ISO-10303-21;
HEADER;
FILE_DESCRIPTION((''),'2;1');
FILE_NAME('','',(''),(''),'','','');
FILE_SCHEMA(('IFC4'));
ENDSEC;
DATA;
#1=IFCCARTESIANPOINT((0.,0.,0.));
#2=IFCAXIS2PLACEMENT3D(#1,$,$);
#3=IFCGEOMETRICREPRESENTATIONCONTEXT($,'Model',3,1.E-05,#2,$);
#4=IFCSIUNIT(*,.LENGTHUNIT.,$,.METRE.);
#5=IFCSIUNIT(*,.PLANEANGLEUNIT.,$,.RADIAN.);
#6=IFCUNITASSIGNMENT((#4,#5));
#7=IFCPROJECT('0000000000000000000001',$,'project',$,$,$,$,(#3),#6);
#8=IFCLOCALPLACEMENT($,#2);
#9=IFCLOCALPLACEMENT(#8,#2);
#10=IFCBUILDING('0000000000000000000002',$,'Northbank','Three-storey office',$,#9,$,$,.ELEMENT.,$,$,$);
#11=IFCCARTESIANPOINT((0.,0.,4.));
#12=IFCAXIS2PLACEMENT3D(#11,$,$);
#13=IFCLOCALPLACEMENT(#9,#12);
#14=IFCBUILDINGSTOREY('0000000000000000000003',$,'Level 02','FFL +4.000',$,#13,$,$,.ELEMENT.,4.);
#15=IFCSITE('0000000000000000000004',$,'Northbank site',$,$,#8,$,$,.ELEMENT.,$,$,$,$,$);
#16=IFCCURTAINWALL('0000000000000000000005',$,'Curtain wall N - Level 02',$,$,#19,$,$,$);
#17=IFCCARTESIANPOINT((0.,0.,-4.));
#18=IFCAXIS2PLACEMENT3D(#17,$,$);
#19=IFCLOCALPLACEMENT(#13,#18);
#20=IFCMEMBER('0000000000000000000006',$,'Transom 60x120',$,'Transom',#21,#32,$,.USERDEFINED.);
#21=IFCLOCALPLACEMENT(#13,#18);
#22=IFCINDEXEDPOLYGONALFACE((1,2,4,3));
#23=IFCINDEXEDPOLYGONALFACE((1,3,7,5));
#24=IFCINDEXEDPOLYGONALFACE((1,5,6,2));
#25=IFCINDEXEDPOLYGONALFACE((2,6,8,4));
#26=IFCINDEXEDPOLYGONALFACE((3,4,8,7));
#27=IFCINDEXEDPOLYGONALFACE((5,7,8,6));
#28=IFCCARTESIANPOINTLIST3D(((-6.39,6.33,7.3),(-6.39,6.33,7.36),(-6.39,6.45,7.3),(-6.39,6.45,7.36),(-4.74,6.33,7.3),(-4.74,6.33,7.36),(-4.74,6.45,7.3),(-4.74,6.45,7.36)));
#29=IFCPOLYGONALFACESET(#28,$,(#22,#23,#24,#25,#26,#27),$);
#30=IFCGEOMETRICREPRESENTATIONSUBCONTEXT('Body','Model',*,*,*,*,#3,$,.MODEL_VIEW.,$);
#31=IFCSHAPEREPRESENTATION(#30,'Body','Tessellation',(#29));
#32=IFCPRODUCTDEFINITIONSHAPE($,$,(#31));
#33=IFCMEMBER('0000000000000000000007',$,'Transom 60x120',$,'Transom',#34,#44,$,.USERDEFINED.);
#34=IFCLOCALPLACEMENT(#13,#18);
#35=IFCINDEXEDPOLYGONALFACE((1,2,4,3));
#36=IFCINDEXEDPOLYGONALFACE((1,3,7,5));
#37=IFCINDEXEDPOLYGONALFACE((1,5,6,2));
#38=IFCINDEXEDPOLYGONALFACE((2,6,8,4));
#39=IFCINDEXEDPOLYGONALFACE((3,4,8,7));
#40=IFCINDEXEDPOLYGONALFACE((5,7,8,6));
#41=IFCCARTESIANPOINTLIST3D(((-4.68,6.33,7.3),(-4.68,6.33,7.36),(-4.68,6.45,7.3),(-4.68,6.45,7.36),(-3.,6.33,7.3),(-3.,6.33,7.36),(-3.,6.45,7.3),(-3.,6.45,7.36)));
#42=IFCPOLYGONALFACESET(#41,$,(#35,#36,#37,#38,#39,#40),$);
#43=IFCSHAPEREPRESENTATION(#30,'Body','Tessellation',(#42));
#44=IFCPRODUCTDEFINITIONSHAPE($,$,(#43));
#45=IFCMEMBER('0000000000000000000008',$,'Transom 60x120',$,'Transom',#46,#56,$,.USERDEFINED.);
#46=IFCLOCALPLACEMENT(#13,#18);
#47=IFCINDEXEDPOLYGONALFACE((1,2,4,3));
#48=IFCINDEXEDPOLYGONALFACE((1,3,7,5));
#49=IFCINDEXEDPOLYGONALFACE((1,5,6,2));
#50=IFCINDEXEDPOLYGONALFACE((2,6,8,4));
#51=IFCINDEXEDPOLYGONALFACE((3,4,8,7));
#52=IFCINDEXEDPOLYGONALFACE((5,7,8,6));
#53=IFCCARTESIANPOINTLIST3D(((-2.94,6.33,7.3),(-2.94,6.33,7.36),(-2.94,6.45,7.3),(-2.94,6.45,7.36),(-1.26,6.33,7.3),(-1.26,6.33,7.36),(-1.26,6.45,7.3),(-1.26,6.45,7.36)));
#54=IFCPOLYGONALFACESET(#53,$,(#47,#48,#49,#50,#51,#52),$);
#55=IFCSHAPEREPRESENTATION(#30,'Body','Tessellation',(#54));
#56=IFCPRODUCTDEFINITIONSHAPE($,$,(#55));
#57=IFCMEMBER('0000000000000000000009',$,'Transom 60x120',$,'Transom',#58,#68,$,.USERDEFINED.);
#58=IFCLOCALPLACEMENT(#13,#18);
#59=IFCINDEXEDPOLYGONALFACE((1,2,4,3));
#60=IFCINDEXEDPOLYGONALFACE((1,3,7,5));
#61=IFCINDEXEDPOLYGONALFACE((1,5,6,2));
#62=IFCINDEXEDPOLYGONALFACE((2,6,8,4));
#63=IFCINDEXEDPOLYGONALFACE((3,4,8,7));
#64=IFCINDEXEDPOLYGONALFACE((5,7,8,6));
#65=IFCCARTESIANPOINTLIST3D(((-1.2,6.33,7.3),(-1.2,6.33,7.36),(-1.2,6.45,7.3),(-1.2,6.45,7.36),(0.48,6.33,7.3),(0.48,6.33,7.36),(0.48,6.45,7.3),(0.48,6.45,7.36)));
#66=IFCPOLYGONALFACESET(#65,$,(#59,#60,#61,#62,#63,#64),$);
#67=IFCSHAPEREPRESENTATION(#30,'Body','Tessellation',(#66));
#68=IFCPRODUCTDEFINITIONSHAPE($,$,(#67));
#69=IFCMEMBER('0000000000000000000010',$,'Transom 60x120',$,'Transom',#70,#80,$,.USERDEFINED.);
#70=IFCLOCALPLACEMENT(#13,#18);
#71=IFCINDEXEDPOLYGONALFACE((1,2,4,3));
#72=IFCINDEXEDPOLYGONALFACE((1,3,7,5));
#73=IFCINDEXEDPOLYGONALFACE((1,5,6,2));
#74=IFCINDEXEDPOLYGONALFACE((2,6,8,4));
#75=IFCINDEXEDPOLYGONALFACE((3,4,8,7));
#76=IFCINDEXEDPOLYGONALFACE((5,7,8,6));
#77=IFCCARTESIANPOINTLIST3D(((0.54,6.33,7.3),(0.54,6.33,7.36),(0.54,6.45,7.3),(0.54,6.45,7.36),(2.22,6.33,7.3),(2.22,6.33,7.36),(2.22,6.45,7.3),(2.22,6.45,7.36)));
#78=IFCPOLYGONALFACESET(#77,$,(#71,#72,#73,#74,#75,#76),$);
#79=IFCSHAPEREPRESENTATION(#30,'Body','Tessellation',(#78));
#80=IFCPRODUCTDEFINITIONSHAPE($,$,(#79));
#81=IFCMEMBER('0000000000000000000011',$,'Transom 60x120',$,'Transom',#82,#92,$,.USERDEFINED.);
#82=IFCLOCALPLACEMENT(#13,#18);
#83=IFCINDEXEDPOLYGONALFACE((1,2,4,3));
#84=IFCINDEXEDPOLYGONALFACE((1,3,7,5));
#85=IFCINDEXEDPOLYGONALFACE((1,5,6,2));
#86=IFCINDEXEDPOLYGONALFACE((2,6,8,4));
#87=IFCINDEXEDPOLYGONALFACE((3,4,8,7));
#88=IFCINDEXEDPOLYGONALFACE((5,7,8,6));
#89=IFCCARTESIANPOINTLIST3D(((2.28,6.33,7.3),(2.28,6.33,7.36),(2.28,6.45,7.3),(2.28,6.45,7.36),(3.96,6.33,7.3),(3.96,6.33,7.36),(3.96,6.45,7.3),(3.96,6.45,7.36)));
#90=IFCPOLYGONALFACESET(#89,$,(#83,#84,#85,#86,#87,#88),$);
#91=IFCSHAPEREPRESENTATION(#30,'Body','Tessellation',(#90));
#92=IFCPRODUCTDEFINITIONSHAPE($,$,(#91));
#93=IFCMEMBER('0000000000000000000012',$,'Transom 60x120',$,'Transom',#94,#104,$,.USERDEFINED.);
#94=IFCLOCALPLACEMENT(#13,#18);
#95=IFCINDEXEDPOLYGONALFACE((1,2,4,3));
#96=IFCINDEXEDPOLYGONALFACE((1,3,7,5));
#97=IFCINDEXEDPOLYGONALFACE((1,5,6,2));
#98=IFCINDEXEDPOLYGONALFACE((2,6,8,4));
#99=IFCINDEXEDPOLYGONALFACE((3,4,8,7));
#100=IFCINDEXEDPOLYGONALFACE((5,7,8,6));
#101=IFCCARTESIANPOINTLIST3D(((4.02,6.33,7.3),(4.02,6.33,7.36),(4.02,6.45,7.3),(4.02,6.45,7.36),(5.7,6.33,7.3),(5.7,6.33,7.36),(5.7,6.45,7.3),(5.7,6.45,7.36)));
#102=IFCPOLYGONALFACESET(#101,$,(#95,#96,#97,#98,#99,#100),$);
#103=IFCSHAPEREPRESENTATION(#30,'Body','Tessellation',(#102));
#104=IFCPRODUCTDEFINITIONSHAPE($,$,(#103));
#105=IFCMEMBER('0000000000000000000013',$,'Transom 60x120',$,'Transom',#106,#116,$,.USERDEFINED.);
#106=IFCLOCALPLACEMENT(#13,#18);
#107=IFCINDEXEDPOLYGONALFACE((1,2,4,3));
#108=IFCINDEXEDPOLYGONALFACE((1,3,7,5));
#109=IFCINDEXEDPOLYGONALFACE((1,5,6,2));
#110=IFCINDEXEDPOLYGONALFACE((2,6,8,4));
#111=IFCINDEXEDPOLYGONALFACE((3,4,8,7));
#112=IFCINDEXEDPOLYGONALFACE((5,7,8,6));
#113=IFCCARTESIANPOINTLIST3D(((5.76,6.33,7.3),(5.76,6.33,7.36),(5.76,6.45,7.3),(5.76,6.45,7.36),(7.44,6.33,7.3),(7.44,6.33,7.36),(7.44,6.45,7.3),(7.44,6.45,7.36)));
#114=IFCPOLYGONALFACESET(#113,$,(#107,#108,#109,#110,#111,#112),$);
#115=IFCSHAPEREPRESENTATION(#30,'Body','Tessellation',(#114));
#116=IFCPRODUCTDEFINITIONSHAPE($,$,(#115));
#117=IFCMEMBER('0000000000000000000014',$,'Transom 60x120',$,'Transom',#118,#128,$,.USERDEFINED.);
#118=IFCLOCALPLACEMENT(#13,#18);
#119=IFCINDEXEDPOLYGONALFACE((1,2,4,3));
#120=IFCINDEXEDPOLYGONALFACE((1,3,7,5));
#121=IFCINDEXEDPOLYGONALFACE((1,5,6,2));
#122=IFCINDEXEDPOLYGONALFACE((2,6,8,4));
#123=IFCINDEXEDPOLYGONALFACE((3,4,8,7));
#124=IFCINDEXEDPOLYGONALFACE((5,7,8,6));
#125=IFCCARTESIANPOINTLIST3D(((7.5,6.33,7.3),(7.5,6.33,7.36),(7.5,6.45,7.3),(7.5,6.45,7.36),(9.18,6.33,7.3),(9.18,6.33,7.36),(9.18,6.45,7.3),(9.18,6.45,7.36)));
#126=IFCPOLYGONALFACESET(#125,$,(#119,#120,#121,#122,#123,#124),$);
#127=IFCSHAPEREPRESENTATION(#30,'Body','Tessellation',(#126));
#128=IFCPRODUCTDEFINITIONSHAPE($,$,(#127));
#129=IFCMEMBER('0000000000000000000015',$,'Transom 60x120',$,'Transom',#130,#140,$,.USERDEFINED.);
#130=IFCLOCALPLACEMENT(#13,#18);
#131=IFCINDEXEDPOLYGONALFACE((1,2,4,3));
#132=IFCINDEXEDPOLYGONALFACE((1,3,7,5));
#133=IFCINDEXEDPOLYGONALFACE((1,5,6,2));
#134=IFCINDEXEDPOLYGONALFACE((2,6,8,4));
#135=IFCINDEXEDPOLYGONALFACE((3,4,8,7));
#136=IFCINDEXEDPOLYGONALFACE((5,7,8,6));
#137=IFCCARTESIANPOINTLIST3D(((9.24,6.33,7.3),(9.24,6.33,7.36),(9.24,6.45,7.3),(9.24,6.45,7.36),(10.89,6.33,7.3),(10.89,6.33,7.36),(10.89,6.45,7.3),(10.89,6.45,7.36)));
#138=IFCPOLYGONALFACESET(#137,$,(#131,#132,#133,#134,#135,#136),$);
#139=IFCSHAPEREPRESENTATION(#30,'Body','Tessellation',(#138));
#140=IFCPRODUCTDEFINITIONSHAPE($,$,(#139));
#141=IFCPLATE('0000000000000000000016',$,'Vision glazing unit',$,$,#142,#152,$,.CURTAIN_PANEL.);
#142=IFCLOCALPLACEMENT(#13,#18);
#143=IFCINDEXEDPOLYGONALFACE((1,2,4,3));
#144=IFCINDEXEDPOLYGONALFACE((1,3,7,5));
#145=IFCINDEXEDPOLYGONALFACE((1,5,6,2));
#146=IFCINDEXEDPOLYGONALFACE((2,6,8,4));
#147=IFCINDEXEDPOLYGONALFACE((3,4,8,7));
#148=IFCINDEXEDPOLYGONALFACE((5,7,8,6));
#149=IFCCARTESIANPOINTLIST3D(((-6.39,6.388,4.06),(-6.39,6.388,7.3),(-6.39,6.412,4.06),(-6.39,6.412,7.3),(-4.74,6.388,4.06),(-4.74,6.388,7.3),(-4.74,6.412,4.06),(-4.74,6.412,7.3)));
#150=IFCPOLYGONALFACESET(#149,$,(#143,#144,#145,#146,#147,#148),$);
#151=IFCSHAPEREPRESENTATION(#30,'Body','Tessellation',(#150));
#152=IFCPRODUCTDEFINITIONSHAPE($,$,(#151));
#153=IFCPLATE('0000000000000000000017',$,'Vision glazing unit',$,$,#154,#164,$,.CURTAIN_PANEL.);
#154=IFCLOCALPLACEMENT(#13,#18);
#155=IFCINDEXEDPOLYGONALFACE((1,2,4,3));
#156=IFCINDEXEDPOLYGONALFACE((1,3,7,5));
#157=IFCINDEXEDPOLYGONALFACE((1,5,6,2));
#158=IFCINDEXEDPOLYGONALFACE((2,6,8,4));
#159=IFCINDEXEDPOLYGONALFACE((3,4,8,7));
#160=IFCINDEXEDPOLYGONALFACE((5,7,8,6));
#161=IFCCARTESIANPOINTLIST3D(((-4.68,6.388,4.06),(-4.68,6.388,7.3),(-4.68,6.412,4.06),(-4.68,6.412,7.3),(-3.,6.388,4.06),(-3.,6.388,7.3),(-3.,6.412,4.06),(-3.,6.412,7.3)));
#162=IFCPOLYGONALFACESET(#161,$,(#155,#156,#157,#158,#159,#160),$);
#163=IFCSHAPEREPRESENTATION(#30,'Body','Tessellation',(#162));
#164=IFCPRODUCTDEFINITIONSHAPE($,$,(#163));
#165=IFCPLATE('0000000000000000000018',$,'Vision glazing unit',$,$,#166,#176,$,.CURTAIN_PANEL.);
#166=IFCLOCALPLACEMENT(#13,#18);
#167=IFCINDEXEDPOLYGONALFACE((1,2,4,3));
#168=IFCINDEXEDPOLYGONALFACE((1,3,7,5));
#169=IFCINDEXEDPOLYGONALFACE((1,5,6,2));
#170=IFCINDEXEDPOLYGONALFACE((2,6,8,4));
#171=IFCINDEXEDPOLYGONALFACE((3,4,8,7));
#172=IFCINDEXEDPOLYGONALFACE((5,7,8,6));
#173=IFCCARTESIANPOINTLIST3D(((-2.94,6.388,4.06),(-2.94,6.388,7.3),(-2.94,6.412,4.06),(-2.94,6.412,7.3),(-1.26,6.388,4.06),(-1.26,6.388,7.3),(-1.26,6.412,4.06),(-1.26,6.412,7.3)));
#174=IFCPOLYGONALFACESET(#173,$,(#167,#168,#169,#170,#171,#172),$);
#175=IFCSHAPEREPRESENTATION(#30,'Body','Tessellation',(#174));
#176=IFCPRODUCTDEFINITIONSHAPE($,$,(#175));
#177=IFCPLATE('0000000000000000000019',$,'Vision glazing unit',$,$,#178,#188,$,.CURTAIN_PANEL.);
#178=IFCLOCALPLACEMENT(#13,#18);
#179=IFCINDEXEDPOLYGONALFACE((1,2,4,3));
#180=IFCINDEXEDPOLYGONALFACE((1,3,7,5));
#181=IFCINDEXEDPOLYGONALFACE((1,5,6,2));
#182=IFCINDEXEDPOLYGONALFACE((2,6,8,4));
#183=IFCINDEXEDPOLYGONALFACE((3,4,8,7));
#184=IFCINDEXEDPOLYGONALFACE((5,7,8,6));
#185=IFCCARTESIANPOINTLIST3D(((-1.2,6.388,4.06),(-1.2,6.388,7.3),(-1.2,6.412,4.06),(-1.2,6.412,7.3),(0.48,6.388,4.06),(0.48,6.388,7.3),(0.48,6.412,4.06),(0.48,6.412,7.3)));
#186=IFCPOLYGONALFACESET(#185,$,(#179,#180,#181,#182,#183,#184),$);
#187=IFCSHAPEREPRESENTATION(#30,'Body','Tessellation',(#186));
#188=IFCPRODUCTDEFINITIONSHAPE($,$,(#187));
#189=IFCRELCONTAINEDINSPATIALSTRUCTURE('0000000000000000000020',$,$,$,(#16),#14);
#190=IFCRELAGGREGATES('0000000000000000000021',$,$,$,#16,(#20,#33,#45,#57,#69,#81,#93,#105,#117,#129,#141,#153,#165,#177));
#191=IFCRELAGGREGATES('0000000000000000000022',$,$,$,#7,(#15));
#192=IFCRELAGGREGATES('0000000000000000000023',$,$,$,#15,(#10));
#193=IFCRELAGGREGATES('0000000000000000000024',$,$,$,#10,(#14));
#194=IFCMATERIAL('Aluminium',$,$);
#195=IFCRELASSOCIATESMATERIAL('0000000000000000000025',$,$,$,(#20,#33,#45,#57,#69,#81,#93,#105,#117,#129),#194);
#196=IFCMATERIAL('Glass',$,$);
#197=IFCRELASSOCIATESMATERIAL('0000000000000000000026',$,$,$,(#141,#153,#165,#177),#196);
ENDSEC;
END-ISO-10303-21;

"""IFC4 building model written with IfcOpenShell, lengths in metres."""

from ifc_helpers import new_model, si_unit, frame, origin, place, context, subcontext, project, spatial, rectangle, extrude, material, element, aggregate, save


model = new_model("IFC4")

# Units and contexts
model_context = context("Model", 3, precision=1e-05, world=origin())
body_context = subcontext(model_context, "Body", "Model", "MODEL_VIEW")
ifc_project = project(units=[si_unit("LENGTHUNIT", "METRE"), si_unit("PLANEANGLEUNIT", "RADIAN")], contexts=[model_context])

# Site, building, storey
site_placement = place(None, origin())
site = spatial("IfcSite", under=ifc_project, at=site_placement, Name="Northbank site", CompositionType="ELEMENT")
building_placement = place(site_placement, origin())
building = spatial("IfcBuilding", under=site, at=building_placement, Name="Northbank", Description="Three-storey office", CompositionType="ELEMENT")
storey_placement = place(building_placement, frame((0.0, 0.0, 4.0)))
storey = spatial("IfcBuildingStorey", under=building, at=storey_placement, Name="Level 02", Description="FFL +4.000", CompositionType="ELEMENT", Elevation=4.0)

# Curtain wall, members, plates
curtain_wall_placement = place(storey_placement, frame((0.0, 0.0, -4.0)))
curtain_wall = element("IfcCurtainWall", 1, at=curtain_wall_placement, inside=storey, Name="Curtain wall N - Level 02")
ifc_material_1 = material(Name="Aluminium")
member_1_placement = place(storey_placement, frame((0.0, 0.0, -4.0)))
member_1 = element("IfcMember", 2, at=member_1_placement, material=ifc_material_1, Name="Transom 60x120", ObjectType="Transom", PredefinedType="USERDEFINED", context=body_context, shape_type="SweptSolid", body=[
    extrude(rectangle(XDim=1.65, YDim=0.12), frame((-5.565, 6.39, 7.3)), (0.0, 0.0, 1.0), 0.06),
])
member_2_placement = place(storey_placement, frame((0.0, 0.0, -4.0)))
member_2 = element("IfcMember", 3, at=member_2_placement, material=ifc_material_1, Name="Transom 60x120", ObjectType="Transom", PredefinedType="USERDEFINED", context=body_context, shape_type="SweptSolid", body=[
    extrude(rectangle(XDim=1.68, YDim=0.12), frame((-3.84, 6.39, 7.3)), (0.0, 0.0, 1.0), 0.06),
])
member_3_placement = place(storey_placement, frame((0.0, 0.0, -4.0)))
member_3 = element("IfcMember", 4, at=member_3_placement, material=ifc_material_1, Name="Transom 60x120", ObjectType="Transom", PredefinedType="USERDEFINED", context=body_context, shape_type="SweptSolid", body=[
    extrude(rectangle(XDim=1.68, YDim=0.12), frame((-2.1, 6.39, 7.3)), (0.0, 0.0, 1.0), 0.06),
])
member_4_placement = place(storey_placement, frame((0.0, 0.0, -4.0)))
member_4 = element("IfcMember", 5, at=member_4_placement, material=ifc_material_1, Name="Transom 60x120", ObjectType="Transom", PredefinedType="USERDEFINED", context=body_context, shape_type="SweptSolid", body=[
    extrude(rectangle(XDim=1.68, YDim=0.12), frame((-0.36, 6.39, 7.3)), (0.0, 0.0, 1.0), 0.06),
])
member_5_placement = place(storey_placement, frame((0.0, 0.0, -4.0)))
member_5 = element("IfcMember", 6, at=member_5_placement, material=ifc_material_1, Name="Transom 60x120", ObjectType="Transom", PredefinedType="USERDEFINED", context=body_context, shape_type="SweptSolid", body=[
    extrude(rectangle(XDim=1.68, YDim=0.12), frame((1.38, 6.39, 7.3)), (0.0, 0.0, 1.0), 0.06),
])
member_6_placement = place(storey_placement, frame((0.0, 0.0, -4.0)))
member_6 = element("IfcMember", 7, at=member_6_placement, material=ifc_material_1, Name="Transom 60x120", ObjectType="Transom", PredefinedType="USERDEFINED", context=body_context, shape_type="SweptSolid", body=[
    extrude(rectangle(XDim=1.68, YDim=0.12), frame((3.12, 6.39, 7.3)), (0.0, 0.0, 1.0), 0.06),
])
member_7_placement = place(storey_placement, frame((0.0, 0.0, -4.0)))
member_7 = element("IfcMember", 8, at=member_7_placement, material=ifc_material_1, Name="Transom 60x120", ObjectType="Transom", PredefinedType="USERDEFINED", context=body_context, shape_type="SweptSolid", body=[
    extrude(rectangle(XDim=1.68, YDim=0.12), frame((4.86, 6.39, 7.3)), (0.0, 0.0, 1.0), 0.06),
])
member_8_placement = place(storey_placement, frame((0.0, 0.0, -4.0)))
member_8 = element("IfcMember", 9, at=member_8_placement, material=ifc_material_1, Name="Transom 60x120", ObjectType="Transom", PredefinedType="USERDEFINED", context=body_context, shape_type="SweptSolid", body=[
    extrude(rectangle(XDim=1.68, YDim=0.12), frame((6.6, 6.39, 7.3)), (0.0, 0.0, 1.0), 0.06),
])
member_9_placement = place(storey_placement, frame((0.0, 0.0, -4.0)))
member_9 = element("IfcMember", 10, at=member_9_placement, material=ifc_material_1, Name="Transom 60x120", ObjectType="Transom", PredefinedType="USERDEFINED", context=body_context, shape_type="SweptSolid", body=[
    extrude(rectangle(XDim=1.68, YDim=0.12), frame((8.34, 6.39, 7.3)), (0.0, 0.0, 1.0), 0.06),
])
member_10_placement = place(storey_placement, frame((0.0, 0.0, -4.0)))
member_10 = element("IfcMember", 11, at=member_10_placement, material=ifc_material_1, Name="Transom 60x120", ObjectType="Transom", PredefinedType="USERDEFINED", context=body_context, shape_type="SweptSolid", body=[
    extrude(rectangle(XDim=1.65, YDim=0.12), frame((10.065, 6.39, 7.3)), (0.0, 0.0, 1.0), 0.06),
])
ifc_material_2 = material(Name="Glass")
plate_1_placement = place(storey_placement, frame((0.0, 0.0, -4.0)))
plate_1 = element("IfcPlate", 12, at=plate_1_placement, material=ifc_material_2, Name="Vision glazing unit", PredefinedType="CURTAIN_PANEL", context=body_context, shape_type="SweptSolid", body=[
    extrude(rectangle(XDim=1.65, YDim=0.024), frame((-5.565, 6.4, 4.06)), (0.0, 0.0, 1.0), 3.24),
])
plate_2_placement = place(storey_placement, frame((0.0, 0.0, -4.0)))
plate_2 = element("IfcPlate", 13, at=plate_2_placement, material=ifc_material_2, Name="Vision glazing unit", PredefinedType="CURTAIN_PANEL", context=body_context, shape_type="SweptSolid", body=[
    extrude(rectangle(XDim=1.68, YDim=0.024), frame((-3.84, 6.4, 4.06)), (0.0, 0.0, 1.0), 3.24),
])
plate_3_placement = place(storey_placement, frame((0.0, 0.0, -4.0)))
plate_3 = element("IfcPlate", 14, at=plate_3_placement, material=ifc_material_2, Name="Vision glazing unit", PredefinedType="CURTAIN_PANEL", context=body_context, shape_type="SweptSolid", body=[
    extrude(rectangle(XDim=1.68, YDim=0.024), frame((-2.1, 6.4, 4.06)), (0.0, 0.0, 1.0), 3.24),
])
plate_4_placement = place(storey_placement, frame((0.0, 0.0, -4.0)))
plate_4 = element("IfcPlate", 15, at=plate_4_placement, material=ifc_material_2, Name="Vision glazing unit", PredefinedType="CURTAIN_PANEL", context=body_context, shape_type="SweptSolid", body=[
    extrude(rectangle(XDim=1.68, YDim=0.024), frame((-0.36, 6.4, 4.06)), (0.0, 0.0, 1.0), 3.24),
])
aggregate(curtain_wall, [member_1, member_2, member_3, member_4, member_5, member_6, member_7, member_8, member_9, member_10, plate_1, plate_2, plate_3, plate_4])

save(model, "model.ifc")
